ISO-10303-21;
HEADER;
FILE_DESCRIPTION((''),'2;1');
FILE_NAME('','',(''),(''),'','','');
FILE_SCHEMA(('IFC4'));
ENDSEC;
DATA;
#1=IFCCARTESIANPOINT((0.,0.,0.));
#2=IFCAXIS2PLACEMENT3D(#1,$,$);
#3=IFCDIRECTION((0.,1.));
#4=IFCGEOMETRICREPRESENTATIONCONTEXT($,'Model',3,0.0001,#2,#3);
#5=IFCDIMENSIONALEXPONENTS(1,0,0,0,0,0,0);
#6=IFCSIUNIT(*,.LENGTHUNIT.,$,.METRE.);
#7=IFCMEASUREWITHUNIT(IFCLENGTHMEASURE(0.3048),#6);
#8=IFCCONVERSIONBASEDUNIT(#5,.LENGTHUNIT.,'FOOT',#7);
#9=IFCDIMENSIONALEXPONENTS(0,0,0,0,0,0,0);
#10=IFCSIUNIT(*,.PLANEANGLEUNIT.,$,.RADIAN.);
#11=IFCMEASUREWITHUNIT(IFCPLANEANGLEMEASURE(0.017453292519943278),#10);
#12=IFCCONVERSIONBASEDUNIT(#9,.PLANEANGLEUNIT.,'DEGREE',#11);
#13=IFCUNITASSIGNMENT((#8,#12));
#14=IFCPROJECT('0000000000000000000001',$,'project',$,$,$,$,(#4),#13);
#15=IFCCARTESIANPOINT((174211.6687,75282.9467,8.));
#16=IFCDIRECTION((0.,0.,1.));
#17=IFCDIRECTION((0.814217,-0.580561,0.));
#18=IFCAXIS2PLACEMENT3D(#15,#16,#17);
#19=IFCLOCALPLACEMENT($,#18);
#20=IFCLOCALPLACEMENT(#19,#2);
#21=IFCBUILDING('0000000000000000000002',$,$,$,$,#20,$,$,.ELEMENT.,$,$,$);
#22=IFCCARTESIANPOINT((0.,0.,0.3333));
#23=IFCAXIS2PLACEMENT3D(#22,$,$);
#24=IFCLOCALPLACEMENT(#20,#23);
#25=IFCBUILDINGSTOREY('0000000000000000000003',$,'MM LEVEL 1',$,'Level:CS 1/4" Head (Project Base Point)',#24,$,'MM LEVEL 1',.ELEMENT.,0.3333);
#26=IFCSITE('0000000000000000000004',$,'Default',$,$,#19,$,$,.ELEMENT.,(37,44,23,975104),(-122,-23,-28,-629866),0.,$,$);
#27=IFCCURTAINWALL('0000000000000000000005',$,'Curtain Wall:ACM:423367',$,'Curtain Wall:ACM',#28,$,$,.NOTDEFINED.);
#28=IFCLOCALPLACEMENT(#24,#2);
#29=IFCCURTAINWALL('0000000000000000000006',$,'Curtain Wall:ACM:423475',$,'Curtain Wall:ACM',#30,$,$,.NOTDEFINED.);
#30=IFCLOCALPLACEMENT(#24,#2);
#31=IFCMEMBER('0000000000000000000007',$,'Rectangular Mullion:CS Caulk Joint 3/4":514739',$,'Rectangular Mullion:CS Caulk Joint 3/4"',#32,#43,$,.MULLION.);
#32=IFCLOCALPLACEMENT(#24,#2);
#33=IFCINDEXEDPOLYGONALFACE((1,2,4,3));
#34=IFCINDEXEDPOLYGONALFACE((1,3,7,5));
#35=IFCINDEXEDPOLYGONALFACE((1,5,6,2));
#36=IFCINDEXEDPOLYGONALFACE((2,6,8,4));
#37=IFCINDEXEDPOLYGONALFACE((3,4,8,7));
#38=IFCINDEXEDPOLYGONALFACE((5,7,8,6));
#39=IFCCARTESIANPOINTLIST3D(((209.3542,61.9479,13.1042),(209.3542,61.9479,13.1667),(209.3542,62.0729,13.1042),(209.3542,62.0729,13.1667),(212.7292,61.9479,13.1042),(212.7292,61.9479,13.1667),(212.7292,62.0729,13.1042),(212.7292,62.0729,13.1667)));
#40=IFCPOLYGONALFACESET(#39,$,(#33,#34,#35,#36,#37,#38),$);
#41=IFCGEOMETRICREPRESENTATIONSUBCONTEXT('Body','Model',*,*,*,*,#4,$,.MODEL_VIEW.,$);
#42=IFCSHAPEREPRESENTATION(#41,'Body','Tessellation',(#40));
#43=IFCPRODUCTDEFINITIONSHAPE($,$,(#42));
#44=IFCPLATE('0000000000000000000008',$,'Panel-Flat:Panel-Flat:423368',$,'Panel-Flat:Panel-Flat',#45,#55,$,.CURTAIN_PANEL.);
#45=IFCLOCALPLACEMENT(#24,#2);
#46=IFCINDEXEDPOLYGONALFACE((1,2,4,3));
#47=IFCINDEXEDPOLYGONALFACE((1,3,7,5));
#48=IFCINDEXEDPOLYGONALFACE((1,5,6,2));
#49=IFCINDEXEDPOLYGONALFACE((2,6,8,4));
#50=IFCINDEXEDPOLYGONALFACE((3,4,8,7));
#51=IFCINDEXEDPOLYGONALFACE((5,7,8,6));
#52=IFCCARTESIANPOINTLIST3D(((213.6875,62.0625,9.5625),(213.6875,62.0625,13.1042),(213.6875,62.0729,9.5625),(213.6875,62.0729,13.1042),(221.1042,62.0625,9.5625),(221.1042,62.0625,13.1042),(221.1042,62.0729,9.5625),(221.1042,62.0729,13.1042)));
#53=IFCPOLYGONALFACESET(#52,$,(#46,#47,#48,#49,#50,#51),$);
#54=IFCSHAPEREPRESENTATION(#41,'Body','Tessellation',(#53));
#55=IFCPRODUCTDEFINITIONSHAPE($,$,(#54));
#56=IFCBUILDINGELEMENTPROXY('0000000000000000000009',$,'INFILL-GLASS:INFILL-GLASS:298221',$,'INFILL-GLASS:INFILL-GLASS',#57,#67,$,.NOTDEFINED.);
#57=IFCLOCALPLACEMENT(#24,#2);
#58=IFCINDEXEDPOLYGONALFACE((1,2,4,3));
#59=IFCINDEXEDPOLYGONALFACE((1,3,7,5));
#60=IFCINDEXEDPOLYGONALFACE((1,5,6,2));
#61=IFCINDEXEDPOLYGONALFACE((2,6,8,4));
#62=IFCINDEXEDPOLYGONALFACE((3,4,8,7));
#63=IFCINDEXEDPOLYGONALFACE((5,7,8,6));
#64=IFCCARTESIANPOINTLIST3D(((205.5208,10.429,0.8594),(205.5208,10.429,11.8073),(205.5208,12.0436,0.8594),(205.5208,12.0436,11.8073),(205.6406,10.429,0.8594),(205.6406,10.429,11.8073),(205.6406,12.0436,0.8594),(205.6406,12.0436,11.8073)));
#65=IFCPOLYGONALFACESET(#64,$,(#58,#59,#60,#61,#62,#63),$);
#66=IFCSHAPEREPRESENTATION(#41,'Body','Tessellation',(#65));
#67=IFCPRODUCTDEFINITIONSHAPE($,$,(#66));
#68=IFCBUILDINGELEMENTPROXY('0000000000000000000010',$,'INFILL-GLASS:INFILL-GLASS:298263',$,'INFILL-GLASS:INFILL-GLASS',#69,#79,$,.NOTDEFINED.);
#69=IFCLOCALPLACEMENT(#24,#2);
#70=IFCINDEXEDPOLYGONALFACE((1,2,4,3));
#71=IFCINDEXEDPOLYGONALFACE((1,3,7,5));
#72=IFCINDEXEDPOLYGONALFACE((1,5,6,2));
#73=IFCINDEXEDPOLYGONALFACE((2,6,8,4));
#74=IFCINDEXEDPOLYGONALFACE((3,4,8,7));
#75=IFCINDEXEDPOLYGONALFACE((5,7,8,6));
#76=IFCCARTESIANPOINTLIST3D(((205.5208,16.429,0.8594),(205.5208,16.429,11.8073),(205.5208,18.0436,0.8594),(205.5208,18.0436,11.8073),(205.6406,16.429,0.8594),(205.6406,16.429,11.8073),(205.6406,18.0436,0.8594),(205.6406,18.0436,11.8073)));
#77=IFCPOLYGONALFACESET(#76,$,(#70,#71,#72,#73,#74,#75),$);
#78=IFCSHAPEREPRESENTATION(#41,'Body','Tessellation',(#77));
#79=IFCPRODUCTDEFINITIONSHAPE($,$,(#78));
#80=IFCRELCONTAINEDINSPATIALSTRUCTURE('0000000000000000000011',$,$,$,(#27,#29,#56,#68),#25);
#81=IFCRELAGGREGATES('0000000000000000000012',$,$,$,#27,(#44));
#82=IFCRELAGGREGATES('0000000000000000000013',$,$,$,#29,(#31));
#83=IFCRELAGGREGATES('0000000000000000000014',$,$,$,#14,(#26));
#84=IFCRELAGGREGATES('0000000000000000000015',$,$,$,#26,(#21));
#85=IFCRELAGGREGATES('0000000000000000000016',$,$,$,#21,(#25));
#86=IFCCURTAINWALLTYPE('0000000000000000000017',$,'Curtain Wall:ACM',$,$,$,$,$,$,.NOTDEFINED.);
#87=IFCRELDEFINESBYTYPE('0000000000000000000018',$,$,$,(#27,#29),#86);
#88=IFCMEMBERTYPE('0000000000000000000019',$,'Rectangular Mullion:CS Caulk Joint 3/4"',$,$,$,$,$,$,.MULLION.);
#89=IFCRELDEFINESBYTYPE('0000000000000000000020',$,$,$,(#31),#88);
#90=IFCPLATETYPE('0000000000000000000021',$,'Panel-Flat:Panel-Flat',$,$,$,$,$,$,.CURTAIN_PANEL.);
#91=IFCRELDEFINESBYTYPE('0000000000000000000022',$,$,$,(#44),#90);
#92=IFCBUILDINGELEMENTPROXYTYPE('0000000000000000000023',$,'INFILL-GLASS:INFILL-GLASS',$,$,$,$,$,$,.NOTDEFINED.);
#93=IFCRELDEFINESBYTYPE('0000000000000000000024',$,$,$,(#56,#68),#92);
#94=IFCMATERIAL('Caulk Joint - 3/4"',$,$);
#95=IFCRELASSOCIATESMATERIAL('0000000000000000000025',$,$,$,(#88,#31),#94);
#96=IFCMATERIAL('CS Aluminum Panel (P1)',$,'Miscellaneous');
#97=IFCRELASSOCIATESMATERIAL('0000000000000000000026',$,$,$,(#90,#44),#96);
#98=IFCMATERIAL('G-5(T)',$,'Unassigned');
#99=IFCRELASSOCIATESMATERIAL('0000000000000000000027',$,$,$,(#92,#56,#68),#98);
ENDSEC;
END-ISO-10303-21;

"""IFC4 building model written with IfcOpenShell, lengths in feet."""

from ifc_helpers import new_model, entity, si_unit, converted_unit, direction, frame, origin, place, context, subcontext, project, spatial, indexed_curve, outline, extrude, source, transform, mapped, material, type_object, type_shapes, element, aggregate, save


model = new_model("IFC4")

# Units and contexts
model_context = context("Model", 3, precision=0.0001, world=origin(), true_north=direction((0.0, 1.0)))
body_context = subcontext(model_context, "Body", "Model", "MODEL_VIEW")
ifc_project = project(units=[converted_unit("LENGTHUNIT", "FOOT", entity("IfcLengthMeasure", 0.3048), si_unit("LENGTHUNIT", "METRE"), dimensions=[1, 0, 0, 0, 0, 0, 0]), converted_unit("PLANEANGLEUNIT", "DEGREE", entity("IfcPlaneAngleMeasure", 0.017453292519943278), si_unit("PLANEANGLEUNIT", "RADIAN"), dimensions=[0, 0, 0, 0, 0, 0, 0])], contexts=[model_context])

# Site, building, storey
site_placement = place(None, frame((174211.6687, 75282.9467, 8.0), z_axis=(0.0, 0.0, 1.0), x_axis=(0.814217, -0.580561, 0.0)))
site = spatial("IfcSite", under=ifc_project, at=site_placement, Name="Default", CompositionType="ELEMENT", RefLatitude=(37, 44, 23, 975104), RefLongitude=(-122, -23, -28, -629866), RefElevation=0.0)
building_placement = place(site_placement, origin())
building = spatial("IfcBuilding", under=site, at=building_placement, CompositionType="ELEMENT")
storey_placement = place(building_placement, frame((0.0, 0.0, 0.3333)))
storey = spatial("IfcBuildingStorey", under=building, at=storey_placement, Name="MM LEVEL 1", ObjectType="Level:CS 1/4\" Head (Project Base Point)", LongName="MM LEVEL 1", CompositionType="ELEMENT", Elevation=0.3333)

# Shared definitions
ifc_material_1 = material(Name="Caulk Joint - 3/4\"")

# Shared definitions
curtain_wall_type_1 = type_object("IfcCurtainWallType", Name="Curtain Wall:ACM", PredefinedType="NOTDEFINED")

# Curtain wall
curtain_wall_1_placement = place(storey_placement, frame((0.0, 0.0, -0.3333)))
curtain_wall_1 = element("IfcCurtainWall", 1, at=curtain_wall_1_placement, inside=storey, type_object=curtain_wall_type_1, Name="Curtain Wall:ACM:423367", ObjectType="Curtain Wall:ACM", PredefinedType="NOTDEFINED")

# Curtain wall, member
curtain_wall_2_placement = place(storey_placement, frame((0.0, 0.0, -0.3333)))
curtain_wall_2 = element("IfcCurtainWall", 2, at=curtain_wall_2_placement, inside=storey, type_object=curtain_wall_type_1, Name="Curtain Wall:ACM:423475", ObjectType="Curtain Wall:ACM", PredefinedType="NOTDEFINED")
member_type_1 = type_object("IfcMemberType", Name="Rectangular Mullion:CS Caulk Joint 3/4\"", PredefinedType="MULLION", material=ifc_material_1)
shared_shape_1 = source(origin(), body_context, "Body", "SweptSolid", [
    extrude(outline(indexed_curve([(-1.6875, -0.0625), (1.6875, -0.0625), (1.6875, 0.0625), (-1.6875, 0.0625), (-1.6875, -0.0625)], self_intersect=False)), frame((-0.0625, 0.0625, -1.6875), z_axis=(1.0, 0.0, 0.0), x_axis=(0.0, 0.0, -1.0)), (0.0, 0.0, 1.0), 0.0625),
])
type_shapes(member_type_1, [shared_shape_1])
member_1_placement = place(curtain_wall_2_placement, frame((212.7292, 62.0729, 13.5), z_axis=(1.0, 0.0, 0.0), x_axis=(0.0, 0.0, 1.0)))
member_1 = element("IfcMember", 3, at=member_1_placement, type_object=member_type_1, material=ifc_material_1, Name="Rectangular Mullion:CS Caulk Joint 3/4\":514739", ObjectType="Rectangular Mullion:CS Caulk Joint 3/4\"", PredefinedType="MULLION", context=body_context, shape_type="MappedRepresentation", body=[
    mapped(shared_shape_1, transform((0.0, 0.0, 0.0), scale=1.0)),
])

# Plate
ifc_material_2 = material(Name="CS Aluminum Panel (P1)", Category="Miscellaneous")
plate_type_1 = type_object("IfcPlateType", Name="Panel-Flat:Panel-Flat", PredefinedType="CURTAIN_PANEL", material=ifc_material_2)
shared_shape_2 = source(origin(), body_context, "Body", "SweptSolid", [
    extrude(outline(indexed_curve([(-0.0052, -3.7083), (0.0052, -3.7083), (0.0052, 3.7083), (-0.0052, 3.7083), (-0.0052, -3.7083)], self_intersect=False)), frame((0.0, -0.0052, 0.0), z_axis=(0.0, 0.0, 1.0), x_axis=(0.0, -1.0, 0.0)), (0.0, 0.0, 1.0), 3.5417),
])
type_shapes(plate_type_1, [shared_shape_2])
plate_1_placement = place(curtain_wall_1_placement, frame((217.3958, 62.0729, 9.8958)))
plate_1 = element("IfcPlate", 4, at=plate_1_placement, type_object=plate_type_1, material=ifc_material_2, Name="Panel-Flat:Panel-Flat:423368", ObjectType="Panel-Flat:Panel-Flat", PredefinedType="CURTAIN_PANEL", context=body_context, shape_type="MappedRepresentation", body=[
    mapped(shared_shape_2, transform((0.0, 0.0, 0.0), scale=1.0)),
])
aggregate(curtain_wall_1, [plate_1])
aggregate(curtain_wall_2, [member_1])

# Building element proxies
ifc_material_3 = material(Name="G-5(T)", Category="Unassigned")
building_element_proxy_type_1 = type_object("IfcBuildingElementProxyType", Name="INFILL-GLASS:INFILL-GLASS", PredefinedType="NOTDEFINED", material=ifc_material_3)
shared_shape_3 = source(origin(), body_context, "Body", "SweptSolid", [
    extrude(outline(indexed_curve([(-0.0599, -0.8073), (0.0599, -0.8073), (0.0599, 0.8073), (-0.0599, 0.8073), (-0.0599, -0.8073)], self_intersect=False)), frame((0.0, 0.1016, 0.1302), z_axis=(0.0, 0.0, 1.0), x_axis=(0.0, 1.0, 0.0)), (0.0, 0.0, 1.0), 10.9479),
])
type_shapes(building_element_proxy_type_1, [shared_shape_3])
for number, where, z_axis, x_axis, name in (
    (5, (205.4792, 11.2363, 0.7292), (0.0, 0.0, 1.0), (0.0, -1.0, 0.0), "INFILL-GLASS:INFILL-GLASS:298221"),
    (6, (205.4792, 17.2363, 0.7292), (0.0, 0.0, 1.0), (0.0, -1.0, 0.0), "INFILL-GLASS:INFILL-GLASS:298263"),
):
    element("IfcBuildingElementProxy", number, at=place(storey_placement, frame(where, z_axis=z_axis, x_axis=x_axis)), inside=storey, type_object=building_element_proxy_type_1, material=ifc_material_3, Name=name, ObjectType="INFILL-GLASS:INFILL-GLASS", PredefinedType="NOTDEFINED", context=body_context, shape_type="MappedRepresentation", body=[
        mapped(shared_shape_3, transform((0.0, 0.0, 0.0), scale=1.0)),
    ])

save(model, "model.ifc")
